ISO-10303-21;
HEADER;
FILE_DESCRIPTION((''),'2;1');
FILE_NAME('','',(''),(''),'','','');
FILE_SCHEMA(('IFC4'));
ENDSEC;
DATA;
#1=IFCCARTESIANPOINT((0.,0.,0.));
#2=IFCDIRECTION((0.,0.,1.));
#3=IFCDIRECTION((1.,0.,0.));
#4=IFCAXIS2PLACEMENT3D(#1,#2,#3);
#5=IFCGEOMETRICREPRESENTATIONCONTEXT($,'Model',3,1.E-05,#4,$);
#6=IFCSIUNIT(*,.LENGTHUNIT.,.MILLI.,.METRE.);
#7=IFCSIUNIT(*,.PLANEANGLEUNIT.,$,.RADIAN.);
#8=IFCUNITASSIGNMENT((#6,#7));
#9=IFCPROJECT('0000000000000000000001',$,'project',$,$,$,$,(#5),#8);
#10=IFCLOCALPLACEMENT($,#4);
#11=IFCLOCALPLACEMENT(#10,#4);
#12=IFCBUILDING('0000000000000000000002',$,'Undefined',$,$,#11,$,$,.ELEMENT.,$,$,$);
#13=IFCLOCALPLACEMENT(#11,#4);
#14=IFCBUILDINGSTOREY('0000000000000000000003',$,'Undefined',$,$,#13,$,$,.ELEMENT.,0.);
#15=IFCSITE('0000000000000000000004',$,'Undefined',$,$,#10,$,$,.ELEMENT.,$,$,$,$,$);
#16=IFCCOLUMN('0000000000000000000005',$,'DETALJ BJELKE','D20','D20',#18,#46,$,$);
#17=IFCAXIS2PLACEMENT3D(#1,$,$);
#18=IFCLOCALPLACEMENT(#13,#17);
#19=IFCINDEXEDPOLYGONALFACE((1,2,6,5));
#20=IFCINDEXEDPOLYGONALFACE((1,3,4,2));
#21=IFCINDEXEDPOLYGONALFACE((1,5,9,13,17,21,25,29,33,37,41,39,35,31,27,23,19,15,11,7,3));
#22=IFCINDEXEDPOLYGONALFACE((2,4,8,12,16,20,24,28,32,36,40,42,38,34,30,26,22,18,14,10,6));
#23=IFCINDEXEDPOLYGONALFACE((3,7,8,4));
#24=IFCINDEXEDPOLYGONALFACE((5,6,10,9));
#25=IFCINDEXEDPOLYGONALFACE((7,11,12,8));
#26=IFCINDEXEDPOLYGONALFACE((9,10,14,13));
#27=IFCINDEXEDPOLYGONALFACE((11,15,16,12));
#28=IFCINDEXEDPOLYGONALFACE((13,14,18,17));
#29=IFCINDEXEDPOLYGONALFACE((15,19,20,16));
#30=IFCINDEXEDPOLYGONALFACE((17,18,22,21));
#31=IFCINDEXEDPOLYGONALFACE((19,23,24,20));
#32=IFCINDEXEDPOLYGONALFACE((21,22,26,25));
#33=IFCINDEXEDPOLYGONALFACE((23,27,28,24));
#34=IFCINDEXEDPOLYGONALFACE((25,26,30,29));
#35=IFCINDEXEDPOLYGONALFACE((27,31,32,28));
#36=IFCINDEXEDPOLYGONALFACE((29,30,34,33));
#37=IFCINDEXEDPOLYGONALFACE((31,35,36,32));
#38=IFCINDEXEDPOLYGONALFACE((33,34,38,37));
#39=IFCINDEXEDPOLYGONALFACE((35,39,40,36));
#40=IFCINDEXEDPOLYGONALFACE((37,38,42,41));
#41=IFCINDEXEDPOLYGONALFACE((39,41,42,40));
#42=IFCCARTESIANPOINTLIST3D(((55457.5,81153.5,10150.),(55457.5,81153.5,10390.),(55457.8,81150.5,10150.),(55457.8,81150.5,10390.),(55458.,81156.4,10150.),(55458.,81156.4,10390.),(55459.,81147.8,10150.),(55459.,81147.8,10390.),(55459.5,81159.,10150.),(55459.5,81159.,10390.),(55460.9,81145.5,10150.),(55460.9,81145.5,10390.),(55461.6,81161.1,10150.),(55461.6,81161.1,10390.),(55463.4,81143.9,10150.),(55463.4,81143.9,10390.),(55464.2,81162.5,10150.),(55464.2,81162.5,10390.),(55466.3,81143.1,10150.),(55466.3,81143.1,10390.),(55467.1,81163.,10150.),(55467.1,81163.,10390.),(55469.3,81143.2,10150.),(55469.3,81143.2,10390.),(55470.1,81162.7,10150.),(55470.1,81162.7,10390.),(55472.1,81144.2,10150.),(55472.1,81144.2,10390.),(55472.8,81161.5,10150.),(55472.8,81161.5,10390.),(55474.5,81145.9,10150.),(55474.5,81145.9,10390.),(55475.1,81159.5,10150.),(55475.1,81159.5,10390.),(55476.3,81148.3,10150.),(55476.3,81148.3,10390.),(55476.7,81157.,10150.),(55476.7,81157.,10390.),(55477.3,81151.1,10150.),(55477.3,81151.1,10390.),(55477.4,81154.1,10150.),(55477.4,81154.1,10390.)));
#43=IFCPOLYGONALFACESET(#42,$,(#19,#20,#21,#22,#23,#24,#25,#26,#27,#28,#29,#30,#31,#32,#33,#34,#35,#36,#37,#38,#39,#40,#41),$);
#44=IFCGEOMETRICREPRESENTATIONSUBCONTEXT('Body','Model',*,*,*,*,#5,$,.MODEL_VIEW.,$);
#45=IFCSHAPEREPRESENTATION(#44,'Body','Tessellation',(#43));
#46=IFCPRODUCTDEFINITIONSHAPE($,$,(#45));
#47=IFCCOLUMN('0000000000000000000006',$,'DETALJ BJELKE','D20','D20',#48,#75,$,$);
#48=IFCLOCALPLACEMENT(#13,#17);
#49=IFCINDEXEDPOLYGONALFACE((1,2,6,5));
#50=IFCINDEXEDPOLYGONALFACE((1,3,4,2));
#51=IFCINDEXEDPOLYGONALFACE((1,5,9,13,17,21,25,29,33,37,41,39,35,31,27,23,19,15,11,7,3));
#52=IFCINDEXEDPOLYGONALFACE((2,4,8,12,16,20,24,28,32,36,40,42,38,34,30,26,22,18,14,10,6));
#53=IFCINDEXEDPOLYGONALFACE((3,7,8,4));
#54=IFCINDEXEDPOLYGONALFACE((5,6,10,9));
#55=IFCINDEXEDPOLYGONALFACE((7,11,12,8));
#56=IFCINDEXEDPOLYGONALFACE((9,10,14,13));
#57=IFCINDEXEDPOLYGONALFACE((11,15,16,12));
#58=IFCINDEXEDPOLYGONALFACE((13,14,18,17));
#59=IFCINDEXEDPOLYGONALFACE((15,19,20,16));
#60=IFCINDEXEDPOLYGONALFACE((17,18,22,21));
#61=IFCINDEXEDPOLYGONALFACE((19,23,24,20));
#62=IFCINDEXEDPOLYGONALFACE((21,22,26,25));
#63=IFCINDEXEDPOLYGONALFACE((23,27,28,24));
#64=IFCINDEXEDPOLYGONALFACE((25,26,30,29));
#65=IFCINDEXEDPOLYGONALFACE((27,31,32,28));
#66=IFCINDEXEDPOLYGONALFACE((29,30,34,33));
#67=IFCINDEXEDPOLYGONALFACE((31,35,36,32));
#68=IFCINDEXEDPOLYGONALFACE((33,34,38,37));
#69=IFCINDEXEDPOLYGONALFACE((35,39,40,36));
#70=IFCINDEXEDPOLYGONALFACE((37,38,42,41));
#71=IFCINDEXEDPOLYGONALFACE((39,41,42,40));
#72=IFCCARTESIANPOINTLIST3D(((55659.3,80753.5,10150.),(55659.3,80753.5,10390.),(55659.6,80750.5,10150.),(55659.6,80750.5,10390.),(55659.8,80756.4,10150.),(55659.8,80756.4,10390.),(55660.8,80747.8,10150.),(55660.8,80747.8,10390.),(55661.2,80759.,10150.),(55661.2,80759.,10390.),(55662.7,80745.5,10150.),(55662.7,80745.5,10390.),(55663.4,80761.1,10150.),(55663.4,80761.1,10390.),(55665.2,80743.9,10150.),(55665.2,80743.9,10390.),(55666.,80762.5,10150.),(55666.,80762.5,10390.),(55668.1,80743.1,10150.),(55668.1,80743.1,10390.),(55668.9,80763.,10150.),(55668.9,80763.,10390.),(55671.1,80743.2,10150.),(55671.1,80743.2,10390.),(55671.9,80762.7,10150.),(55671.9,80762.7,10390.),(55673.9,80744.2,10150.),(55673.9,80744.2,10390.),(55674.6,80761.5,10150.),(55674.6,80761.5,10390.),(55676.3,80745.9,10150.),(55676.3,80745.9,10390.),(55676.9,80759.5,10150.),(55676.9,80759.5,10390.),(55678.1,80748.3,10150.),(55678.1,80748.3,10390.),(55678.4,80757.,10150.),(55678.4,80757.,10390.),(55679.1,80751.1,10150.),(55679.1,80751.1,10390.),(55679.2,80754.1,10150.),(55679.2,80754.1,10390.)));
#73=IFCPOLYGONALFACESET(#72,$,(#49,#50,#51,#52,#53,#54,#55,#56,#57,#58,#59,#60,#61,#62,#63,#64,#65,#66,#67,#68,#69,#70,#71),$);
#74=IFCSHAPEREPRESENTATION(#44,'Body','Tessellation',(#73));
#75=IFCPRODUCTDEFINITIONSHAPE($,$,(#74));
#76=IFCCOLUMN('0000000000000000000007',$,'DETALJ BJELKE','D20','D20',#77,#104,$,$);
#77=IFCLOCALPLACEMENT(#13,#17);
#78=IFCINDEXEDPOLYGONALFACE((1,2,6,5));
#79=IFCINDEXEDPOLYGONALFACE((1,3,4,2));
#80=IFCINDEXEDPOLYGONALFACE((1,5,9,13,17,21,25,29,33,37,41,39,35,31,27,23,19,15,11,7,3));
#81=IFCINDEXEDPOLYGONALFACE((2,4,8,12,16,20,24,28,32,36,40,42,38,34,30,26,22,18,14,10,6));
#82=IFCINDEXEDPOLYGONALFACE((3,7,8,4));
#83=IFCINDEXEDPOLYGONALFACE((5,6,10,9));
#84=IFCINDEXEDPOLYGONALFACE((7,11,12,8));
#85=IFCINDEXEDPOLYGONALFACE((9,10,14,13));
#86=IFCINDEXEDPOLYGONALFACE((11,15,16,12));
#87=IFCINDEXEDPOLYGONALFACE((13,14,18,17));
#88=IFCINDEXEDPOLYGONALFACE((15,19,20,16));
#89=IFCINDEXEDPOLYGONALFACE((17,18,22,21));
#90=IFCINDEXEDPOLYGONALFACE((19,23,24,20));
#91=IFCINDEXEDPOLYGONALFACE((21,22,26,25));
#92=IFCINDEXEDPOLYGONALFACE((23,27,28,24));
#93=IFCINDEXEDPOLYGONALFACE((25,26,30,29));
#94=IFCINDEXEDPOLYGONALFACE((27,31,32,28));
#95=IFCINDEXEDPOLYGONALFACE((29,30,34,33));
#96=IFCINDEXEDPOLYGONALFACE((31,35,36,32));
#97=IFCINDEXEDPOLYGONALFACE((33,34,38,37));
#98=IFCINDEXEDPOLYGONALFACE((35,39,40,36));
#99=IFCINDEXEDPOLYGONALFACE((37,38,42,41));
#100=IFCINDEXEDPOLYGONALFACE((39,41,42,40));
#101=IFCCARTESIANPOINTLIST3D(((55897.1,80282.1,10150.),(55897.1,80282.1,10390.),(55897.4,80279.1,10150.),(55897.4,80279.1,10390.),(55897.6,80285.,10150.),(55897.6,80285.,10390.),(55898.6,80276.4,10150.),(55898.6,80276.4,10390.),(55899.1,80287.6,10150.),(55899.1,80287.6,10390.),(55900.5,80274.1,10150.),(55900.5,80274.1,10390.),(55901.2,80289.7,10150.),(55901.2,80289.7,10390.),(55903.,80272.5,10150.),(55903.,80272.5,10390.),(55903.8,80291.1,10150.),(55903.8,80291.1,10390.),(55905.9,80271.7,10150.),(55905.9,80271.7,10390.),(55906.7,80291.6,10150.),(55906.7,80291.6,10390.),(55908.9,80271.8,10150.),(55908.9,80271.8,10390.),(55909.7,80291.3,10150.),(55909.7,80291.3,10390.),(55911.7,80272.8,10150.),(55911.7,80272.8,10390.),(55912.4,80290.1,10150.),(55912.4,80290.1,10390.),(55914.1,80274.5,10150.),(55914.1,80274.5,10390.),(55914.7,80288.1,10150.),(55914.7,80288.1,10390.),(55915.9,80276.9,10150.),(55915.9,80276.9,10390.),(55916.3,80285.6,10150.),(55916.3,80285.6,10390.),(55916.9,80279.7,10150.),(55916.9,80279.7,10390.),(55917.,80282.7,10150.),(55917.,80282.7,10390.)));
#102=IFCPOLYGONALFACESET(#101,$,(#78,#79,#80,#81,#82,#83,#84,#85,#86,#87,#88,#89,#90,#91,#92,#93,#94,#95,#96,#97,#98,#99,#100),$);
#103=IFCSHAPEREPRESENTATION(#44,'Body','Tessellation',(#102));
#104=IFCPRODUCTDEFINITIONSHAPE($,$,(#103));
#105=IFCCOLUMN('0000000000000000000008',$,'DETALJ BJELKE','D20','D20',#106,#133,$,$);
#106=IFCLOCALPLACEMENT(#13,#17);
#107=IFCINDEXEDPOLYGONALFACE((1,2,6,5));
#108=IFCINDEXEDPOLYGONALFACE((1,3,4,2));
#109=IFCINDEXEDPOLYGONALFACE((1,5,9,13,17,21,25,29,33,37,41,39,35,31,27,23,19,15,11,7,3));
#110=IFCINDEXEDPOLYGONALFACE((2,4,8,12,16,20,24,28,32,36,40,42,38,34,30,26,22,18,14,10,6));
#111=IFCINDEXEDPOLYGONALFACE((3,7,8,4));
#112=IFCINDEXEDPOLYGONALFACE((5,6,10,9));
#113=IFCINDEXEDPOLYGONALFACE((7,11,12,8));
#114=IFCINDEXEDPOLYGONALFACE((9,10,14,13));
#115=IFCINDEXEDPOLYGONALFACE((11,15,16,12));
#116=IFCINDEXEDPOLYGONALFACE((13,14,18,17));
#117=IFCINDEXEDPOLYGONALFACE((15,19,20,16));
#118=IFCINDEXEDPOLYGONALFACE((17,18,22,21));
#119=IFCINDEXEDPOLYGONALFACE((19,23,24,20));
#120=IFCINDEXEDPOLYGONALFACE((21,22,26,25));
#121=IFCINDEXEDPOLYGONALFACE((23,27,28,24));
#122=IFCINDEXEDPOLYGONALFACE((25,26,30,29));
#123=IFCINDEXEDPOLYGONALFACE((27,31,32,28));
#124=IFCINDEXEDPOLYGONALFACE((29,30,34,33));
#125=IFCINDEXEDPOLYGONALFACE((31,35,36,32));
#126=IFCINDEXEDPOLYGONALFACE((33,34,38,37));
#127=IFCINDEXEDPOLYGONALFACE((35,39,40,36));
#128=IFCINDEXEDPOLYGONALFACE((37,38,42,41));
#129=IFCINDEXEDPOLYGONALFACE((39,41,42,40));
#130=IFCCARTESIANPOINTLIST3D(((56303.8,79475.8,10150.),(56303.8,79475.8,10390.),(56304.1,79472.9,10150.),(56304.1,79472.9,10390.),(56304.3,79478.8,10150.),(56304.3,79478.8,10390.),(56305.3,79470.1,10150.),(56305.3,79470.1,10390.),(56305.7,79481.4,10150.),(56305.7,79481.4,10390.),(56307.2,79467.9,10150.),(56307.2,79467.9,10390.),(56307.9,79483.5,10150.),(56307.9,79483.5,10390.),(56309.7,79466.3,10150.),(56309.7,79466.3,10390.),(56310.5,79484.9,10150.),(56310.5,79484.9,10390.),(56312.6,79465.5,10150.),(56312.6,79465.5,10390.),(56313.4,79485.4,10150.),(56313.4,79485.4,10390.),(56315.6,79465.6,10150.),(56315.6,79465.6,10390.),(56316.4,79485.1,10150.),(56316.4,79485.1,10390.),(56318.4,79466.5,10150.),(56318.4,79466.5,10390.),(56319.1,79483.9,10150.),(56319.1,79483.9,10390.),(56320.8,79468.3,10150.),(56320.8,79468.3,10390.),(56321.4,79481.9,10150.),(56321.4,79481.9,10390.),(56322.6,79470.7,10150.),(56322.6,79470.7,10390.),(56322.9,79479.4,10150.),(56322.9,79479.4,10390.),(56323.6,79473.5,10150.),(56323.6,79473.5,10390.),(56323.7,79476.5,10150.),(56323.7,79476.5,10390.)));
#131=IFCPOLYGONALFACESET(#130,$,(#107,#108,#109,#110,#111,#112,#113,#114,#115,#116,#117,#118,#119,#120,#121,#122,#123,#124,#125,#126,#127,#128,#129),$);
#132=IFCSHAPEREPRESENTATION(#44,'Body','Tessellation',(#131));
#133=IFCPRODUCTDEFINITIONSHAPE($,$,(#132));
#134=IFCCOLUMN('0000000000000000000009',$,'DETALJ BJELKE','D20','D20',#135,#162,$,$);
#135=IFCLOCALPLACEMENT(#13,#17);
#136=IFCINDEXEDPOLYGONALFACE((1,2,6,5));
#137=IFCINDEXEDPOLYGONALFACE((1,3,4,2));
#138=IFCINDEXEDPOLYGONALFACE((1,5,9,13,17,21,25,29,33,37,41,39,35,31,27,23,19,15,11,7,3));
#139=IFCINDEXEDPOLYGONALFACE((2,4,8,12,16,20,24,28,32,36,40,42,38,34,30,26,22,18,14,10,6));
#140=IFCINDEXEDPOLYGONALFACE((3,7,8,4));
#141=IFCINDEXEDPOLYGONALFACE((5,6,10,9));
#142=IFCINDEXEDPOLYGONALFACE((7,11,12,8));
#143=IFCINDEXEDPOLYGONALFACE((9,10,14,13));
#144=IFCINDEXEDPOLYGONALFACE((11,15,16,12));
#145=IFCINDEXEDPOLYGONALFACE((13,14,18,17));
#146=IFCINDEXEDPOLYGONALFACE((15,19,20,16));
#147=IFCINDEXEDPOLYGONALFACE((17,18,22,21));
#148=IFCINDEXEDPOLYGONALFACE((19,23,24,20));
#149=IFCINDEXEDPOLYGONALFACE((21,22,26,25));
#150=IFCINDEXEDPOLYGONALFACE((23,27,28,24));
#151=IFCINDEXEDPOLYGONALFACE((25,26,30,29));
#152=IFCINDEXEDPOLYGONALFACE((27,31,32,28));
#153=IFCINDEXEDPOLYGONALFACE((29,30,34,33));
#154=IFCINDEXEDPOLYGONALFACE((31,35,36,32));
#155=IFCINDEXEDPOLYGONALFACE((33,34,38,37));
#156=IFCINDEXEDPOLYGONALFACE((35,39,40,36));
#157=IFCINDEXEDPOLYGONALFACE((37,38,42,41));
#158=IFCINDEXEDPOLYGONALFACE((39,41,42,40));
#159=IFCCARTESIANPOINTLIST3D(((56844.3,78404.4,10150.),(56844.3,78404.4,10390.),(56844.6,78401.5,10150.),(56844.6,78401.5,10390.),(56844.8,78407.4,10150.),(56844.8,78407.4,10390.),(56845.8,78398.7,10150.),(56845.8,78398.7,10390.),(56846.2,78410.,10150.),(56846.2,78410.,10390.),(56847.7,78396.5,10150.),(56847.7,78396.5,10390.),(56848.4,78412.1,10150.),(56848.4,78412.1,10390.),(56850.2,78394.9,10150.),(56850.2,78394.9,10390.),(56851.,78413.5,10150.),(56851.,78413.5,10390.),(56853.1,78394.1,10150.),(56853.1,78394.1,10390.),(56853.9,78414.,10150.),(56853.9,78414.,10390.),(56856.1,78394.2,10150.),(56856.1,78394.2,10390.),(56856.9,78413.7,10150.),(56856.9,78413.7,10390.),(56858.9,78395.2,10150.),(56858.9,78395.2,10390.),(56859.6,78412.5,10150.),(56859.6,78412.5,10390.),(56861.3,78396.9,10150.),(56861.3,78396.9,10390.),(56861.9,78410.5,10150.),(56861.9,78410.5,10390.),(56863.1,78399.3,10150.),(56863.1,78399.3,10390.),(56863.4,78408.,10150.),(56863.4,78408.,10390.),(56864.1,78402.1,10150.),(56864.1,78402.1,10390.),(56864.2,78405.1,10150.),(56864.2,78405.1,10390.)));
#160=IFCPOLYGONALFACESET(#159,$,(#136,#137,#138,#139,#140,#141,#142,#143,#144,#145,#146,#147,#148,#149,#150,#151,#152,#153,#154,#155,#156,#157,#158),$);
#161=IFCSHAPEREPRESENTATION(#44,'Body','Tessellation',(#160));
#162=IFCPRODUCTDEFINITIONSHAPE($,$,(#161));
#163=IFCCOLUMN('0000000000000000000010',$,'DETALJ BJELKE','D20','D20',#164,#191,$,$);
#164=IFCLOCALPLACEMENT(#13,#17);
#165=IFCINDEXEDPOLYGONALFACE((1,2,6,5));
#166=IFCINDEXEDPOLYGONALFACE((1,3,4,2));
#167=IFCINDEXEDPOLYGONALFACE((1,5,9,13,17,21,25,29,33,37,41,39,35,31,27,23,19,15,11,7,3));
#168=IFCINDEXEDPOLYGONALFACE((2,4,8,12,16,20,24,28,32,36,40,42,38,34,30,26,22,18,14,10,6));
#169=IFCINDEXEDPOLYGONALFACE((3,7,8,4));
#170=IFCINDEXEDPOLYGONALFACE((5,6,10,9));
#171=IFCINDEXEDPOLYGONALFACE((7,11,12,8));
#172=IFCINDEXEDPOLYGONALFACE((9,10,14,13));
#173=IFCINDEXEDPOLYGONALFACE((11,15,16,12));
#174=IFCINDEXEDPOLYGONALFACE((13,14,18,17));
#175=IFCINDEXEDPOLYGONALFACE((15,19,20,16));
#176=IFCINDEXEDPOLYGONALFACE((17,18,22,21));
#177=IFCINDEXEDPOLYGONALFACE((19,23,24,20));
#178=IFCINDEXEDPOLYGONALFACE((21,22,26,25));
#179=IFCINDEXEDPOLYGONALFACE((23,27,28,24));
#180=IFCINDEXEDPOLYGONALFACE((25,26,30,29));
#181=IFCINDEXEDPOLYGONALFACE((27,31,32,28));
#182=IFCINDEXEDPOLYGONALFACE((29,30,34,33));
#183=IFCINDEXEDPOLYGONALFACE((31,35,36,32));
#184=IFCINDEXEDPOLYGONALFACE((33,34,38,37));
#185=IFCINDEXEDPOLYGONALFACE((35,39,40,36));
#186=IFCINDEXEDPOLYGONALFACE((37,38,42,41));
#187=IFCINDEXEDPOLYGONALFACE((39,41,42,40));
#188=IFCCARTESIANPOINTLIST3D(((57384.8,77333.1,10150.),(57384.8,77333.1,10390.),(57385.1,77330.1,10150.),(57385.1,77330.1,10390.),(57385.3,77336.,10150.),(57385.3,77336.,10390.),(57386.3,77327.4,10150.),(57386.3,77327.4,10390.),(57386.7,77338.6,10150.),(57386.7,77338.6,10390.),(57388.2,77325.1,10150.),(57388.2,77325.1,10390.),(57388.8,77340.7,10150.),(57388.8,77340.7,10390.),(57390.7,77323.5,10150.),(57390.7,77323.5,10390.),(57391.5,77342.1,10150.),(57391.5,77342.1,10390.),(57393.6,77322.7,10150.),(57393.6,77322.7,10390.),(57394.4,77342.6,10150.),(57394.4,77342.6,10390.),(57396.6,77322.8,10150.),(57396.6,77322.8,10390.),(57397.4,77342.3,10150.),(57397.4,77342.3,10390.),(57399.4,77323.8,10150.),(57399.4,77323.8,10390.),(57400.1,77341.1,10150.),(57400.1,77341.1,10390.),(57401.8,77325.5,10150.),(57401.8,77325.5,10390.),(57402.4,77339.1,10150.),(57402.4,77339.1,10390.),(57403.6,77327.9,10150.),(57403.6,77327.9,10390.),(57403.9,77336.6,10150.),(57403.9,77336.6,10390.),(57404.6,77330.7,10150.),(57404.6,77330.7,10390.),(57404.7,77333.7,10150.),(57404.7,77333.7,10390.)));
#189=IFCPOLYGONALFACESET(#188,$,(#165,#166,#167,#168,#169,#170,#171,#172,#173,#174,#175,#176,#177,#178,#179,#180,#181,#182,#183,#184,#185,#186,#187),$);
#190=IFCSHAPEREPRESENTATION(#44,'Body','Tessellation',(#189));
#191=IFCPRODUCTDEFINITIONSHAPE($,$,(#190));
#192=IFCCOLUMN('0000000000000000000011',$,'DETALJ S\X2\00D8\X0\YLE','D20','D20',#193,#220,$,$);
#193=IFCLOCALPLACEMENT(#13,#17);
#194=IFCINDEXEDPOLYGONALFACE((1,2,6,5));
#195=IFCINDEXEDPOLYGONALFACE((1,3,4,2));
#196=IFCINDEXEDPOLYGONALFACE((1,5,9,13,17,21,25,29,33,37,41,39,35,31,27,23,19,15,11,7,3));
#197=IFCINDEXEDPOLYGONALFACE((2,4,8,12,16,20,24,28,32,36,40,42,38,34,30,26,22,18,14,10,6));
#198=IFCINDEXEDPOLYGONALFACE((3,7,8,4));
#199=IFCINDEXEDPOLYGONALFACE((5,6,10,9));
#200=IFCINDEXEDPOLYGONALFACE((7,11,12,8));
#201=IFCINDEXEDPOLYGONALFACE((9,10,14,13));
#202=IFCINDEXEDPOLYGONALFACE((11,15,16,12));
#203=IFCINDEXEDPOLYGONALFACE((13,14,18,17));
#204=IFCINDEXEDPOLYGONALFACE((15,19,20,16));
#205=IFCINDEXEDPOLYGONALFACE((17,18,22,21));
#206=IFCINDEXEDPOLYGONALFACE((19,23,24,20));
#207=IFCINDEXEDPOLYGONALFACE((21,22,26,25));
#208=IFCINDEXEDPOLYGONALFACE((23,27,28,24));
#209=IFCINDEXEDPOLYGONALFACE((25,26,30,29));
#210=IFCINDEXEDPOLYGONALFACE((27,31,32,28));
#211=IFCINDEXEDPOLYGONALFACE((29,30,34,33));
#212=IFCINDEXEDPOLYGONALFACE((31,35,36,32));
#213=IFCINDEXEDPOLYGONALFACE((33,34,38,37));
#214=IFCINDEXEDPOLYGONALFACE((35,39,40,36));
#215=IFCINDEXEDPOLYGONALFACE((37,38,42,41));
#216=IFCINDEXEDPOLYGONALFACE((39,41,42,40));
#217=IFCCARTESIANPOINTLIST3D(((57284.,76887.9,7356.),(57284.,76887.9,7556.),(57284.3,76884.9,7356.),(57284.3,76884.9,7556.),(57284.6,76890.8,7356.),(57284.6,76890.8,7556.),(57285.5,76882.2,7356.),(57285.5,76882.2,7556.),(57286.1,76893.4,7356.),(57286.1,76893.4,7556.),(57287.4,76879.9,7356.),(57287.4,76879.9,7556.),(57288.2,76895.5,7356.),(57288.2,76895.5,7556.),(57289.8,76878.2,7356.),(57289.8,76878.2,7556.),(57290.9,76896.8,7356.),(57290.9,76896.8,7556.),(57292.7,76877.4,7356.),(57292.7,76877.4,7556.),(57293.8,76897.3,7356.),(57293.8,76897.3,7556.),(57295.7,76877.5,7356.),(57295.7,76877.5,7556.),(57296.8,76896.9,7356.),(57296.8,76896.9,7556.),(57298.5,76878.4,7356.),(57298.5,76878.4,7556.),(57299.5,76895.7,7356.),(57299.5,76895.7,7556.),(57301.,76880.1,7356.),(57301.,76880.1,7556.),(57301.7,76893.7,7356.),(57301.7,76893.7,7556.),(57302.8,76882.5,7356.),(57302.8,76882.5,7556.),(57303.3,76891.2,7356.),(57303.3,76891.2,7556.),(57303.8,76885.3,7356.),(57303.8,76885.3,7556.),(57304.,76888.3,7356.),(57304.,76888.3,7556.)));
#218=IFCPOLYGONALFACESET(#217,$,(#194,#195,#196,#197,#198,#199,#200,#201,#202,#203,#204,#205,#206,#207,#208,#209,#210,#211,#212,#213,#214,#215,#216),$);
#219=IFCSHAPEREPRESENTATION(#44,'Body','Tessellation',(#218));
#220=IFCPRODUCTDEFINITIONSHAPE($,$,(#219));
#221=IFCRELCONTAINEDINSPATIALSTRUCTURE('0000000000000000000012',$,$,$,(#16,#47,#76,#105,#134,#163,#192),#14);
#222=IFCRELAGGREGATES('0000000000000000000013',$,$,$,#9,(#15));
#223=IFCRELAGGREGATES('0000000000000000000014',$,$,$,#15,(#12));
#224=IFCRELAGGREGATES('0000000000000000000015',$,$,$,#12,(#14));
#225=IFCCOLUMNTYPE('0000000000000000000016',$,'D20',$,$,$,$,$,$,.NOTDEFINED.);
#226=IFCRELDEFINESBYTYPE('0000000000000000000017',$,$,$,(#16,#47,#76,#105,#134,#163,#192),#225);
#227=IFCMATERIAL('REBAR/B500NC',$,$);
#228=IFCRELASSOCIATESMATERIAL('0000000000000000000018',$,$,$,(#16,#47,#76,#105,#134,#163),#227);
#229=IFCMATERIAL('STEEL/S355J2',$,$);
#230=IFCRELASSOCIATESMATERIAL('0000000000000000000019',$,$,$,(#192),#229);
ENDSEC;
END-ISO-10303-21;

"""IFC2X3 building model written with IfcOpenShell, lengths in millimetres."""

from ifc_helpers import new_model, si_unit, frame, origin_with_axes, origin_2d_with_axis, place, context, subcontext, project, spatial, circle, extrude, material, type_object, element, save


model = new_model("IFC2X3")

# Units and contexts
model_context = context("Model", 3, precision=1e-05, world=origin_with_axes())
body_context = subcontext(model_context, "Body", "Model", "MODEL_VIEW")
ifc_project = project(units=[si_unit("LENGTHUNIT", "METRE", prefix="MILLI"), si_unit("PLANEANGLEUNIT", "RADIAN")], contexts=[model_context])

# Site, building, storey
site_placement = place(None, origin_with_axes())
site = spatial("IfcSite", under=ifc_project, at=site_placement, Name="Undefined", CompositionType="ELEMENT")
building_placement = place(site_placement, origin_with_axes())
building = spatial("IfcBuilding", under=site, at=building_placement, Name="Undefined", CompositionType="ELEMENT")
storey_placement = place(building_placement, origin_with_axes())
storey = spatial("IfcBuildingStorey", under=building, at=storey_placement, Name="Undefined", CompositionType="ELEMENT", Elevation=0.0)

# Columns
ifc_material_1 = material(Name="REBAR/B500NC")
column_type = type_object("IfcColumnType", Name="D20", PredefinedType="NOTDEFINED")
for number, where, z_axis, x_axis, name in (
    (1, (55467.5, 81153.0, 10150.0), (0.0, 0.0, 1.0), (-0.886365, -0.462987, 0.0), "DETALJ BJELKE"),
    (2, (55669.3, 80753.1, 10150.0), (0.0, 0.0, 1.0), (-0.886365, -0.462987, 0.0), "DETALJ BJELKE"),
    (3, (55907.1, 80281.6, 10150.0), (0.0, 0.0, 1.0), (-0.886365, -0.462987, 0.0), "DETALJ BJELKE"),
    (4, (56313.8, 79475.4, 10150.0), (0.0, 0.0, 1.0), (-0.886365, -0.462987, 0.0), "DETALJ BJELKE"),
    (5, (56854.3, 78404.0, 10150.0), (0.0, 0.0, 1.0), (-0.886365, -0.462987, 0.0), "DETALJ BJELKE"),
    (6, (57394.7, 77332.6, 10150.0), (0.0, 0.0, 1.0), (-0.886365, -0.462987, 0.0), "DETALJ BJELKE"),
):
    element("IfcColumn", number, at=place(storey_placement, frame(where, z_axis=z_axis, x_axis=x_axis)), inside=storey, type_object=column_type, material=ifc_material_1, Name=name, Description="D20", ObjectType="D20", context=body_context, shape_type="SweptSolid", body=[
        extrude(circle(Radius=10.0, at=origin_2d_with_axis()), frame((0.0, 0.0, 240.0), z_axis=(0.0, 0.0, -1.0), x_axis=(0.0, 1.0, 0.0)), (0.0, 0.0, 1.0), 240.0),
    ])
ifc_material_2 = material(Name="STEEL/S355J2")
column_placement = place(storey_placement, frame((57294.0, 76887.3, 7356.0), z_axis=(0.0, 0.0, 1.0), x_axis=(-0.892821, -0.450411, 0.0)))
element("IfcColumn", 7, at=column_placement, inside=storey, type_object=column_type, material=ifc_material_2, Name="DETALJ SØYLE", Description="D20", ObjectType="D20", context=body_context, shape_type="SweptSolid", body=[
    extrude(circle(Radius=10.0, at=origin_2d_with_axis()), frame((0.0, 0.0, 200.0), z_axis=(0.0, 0.0, -1.0), x_axis=(0.0, 1.0, 0.0)), (0.0, 0.0, 1.0), 200.0),
])

save(model, "model.ifc")
